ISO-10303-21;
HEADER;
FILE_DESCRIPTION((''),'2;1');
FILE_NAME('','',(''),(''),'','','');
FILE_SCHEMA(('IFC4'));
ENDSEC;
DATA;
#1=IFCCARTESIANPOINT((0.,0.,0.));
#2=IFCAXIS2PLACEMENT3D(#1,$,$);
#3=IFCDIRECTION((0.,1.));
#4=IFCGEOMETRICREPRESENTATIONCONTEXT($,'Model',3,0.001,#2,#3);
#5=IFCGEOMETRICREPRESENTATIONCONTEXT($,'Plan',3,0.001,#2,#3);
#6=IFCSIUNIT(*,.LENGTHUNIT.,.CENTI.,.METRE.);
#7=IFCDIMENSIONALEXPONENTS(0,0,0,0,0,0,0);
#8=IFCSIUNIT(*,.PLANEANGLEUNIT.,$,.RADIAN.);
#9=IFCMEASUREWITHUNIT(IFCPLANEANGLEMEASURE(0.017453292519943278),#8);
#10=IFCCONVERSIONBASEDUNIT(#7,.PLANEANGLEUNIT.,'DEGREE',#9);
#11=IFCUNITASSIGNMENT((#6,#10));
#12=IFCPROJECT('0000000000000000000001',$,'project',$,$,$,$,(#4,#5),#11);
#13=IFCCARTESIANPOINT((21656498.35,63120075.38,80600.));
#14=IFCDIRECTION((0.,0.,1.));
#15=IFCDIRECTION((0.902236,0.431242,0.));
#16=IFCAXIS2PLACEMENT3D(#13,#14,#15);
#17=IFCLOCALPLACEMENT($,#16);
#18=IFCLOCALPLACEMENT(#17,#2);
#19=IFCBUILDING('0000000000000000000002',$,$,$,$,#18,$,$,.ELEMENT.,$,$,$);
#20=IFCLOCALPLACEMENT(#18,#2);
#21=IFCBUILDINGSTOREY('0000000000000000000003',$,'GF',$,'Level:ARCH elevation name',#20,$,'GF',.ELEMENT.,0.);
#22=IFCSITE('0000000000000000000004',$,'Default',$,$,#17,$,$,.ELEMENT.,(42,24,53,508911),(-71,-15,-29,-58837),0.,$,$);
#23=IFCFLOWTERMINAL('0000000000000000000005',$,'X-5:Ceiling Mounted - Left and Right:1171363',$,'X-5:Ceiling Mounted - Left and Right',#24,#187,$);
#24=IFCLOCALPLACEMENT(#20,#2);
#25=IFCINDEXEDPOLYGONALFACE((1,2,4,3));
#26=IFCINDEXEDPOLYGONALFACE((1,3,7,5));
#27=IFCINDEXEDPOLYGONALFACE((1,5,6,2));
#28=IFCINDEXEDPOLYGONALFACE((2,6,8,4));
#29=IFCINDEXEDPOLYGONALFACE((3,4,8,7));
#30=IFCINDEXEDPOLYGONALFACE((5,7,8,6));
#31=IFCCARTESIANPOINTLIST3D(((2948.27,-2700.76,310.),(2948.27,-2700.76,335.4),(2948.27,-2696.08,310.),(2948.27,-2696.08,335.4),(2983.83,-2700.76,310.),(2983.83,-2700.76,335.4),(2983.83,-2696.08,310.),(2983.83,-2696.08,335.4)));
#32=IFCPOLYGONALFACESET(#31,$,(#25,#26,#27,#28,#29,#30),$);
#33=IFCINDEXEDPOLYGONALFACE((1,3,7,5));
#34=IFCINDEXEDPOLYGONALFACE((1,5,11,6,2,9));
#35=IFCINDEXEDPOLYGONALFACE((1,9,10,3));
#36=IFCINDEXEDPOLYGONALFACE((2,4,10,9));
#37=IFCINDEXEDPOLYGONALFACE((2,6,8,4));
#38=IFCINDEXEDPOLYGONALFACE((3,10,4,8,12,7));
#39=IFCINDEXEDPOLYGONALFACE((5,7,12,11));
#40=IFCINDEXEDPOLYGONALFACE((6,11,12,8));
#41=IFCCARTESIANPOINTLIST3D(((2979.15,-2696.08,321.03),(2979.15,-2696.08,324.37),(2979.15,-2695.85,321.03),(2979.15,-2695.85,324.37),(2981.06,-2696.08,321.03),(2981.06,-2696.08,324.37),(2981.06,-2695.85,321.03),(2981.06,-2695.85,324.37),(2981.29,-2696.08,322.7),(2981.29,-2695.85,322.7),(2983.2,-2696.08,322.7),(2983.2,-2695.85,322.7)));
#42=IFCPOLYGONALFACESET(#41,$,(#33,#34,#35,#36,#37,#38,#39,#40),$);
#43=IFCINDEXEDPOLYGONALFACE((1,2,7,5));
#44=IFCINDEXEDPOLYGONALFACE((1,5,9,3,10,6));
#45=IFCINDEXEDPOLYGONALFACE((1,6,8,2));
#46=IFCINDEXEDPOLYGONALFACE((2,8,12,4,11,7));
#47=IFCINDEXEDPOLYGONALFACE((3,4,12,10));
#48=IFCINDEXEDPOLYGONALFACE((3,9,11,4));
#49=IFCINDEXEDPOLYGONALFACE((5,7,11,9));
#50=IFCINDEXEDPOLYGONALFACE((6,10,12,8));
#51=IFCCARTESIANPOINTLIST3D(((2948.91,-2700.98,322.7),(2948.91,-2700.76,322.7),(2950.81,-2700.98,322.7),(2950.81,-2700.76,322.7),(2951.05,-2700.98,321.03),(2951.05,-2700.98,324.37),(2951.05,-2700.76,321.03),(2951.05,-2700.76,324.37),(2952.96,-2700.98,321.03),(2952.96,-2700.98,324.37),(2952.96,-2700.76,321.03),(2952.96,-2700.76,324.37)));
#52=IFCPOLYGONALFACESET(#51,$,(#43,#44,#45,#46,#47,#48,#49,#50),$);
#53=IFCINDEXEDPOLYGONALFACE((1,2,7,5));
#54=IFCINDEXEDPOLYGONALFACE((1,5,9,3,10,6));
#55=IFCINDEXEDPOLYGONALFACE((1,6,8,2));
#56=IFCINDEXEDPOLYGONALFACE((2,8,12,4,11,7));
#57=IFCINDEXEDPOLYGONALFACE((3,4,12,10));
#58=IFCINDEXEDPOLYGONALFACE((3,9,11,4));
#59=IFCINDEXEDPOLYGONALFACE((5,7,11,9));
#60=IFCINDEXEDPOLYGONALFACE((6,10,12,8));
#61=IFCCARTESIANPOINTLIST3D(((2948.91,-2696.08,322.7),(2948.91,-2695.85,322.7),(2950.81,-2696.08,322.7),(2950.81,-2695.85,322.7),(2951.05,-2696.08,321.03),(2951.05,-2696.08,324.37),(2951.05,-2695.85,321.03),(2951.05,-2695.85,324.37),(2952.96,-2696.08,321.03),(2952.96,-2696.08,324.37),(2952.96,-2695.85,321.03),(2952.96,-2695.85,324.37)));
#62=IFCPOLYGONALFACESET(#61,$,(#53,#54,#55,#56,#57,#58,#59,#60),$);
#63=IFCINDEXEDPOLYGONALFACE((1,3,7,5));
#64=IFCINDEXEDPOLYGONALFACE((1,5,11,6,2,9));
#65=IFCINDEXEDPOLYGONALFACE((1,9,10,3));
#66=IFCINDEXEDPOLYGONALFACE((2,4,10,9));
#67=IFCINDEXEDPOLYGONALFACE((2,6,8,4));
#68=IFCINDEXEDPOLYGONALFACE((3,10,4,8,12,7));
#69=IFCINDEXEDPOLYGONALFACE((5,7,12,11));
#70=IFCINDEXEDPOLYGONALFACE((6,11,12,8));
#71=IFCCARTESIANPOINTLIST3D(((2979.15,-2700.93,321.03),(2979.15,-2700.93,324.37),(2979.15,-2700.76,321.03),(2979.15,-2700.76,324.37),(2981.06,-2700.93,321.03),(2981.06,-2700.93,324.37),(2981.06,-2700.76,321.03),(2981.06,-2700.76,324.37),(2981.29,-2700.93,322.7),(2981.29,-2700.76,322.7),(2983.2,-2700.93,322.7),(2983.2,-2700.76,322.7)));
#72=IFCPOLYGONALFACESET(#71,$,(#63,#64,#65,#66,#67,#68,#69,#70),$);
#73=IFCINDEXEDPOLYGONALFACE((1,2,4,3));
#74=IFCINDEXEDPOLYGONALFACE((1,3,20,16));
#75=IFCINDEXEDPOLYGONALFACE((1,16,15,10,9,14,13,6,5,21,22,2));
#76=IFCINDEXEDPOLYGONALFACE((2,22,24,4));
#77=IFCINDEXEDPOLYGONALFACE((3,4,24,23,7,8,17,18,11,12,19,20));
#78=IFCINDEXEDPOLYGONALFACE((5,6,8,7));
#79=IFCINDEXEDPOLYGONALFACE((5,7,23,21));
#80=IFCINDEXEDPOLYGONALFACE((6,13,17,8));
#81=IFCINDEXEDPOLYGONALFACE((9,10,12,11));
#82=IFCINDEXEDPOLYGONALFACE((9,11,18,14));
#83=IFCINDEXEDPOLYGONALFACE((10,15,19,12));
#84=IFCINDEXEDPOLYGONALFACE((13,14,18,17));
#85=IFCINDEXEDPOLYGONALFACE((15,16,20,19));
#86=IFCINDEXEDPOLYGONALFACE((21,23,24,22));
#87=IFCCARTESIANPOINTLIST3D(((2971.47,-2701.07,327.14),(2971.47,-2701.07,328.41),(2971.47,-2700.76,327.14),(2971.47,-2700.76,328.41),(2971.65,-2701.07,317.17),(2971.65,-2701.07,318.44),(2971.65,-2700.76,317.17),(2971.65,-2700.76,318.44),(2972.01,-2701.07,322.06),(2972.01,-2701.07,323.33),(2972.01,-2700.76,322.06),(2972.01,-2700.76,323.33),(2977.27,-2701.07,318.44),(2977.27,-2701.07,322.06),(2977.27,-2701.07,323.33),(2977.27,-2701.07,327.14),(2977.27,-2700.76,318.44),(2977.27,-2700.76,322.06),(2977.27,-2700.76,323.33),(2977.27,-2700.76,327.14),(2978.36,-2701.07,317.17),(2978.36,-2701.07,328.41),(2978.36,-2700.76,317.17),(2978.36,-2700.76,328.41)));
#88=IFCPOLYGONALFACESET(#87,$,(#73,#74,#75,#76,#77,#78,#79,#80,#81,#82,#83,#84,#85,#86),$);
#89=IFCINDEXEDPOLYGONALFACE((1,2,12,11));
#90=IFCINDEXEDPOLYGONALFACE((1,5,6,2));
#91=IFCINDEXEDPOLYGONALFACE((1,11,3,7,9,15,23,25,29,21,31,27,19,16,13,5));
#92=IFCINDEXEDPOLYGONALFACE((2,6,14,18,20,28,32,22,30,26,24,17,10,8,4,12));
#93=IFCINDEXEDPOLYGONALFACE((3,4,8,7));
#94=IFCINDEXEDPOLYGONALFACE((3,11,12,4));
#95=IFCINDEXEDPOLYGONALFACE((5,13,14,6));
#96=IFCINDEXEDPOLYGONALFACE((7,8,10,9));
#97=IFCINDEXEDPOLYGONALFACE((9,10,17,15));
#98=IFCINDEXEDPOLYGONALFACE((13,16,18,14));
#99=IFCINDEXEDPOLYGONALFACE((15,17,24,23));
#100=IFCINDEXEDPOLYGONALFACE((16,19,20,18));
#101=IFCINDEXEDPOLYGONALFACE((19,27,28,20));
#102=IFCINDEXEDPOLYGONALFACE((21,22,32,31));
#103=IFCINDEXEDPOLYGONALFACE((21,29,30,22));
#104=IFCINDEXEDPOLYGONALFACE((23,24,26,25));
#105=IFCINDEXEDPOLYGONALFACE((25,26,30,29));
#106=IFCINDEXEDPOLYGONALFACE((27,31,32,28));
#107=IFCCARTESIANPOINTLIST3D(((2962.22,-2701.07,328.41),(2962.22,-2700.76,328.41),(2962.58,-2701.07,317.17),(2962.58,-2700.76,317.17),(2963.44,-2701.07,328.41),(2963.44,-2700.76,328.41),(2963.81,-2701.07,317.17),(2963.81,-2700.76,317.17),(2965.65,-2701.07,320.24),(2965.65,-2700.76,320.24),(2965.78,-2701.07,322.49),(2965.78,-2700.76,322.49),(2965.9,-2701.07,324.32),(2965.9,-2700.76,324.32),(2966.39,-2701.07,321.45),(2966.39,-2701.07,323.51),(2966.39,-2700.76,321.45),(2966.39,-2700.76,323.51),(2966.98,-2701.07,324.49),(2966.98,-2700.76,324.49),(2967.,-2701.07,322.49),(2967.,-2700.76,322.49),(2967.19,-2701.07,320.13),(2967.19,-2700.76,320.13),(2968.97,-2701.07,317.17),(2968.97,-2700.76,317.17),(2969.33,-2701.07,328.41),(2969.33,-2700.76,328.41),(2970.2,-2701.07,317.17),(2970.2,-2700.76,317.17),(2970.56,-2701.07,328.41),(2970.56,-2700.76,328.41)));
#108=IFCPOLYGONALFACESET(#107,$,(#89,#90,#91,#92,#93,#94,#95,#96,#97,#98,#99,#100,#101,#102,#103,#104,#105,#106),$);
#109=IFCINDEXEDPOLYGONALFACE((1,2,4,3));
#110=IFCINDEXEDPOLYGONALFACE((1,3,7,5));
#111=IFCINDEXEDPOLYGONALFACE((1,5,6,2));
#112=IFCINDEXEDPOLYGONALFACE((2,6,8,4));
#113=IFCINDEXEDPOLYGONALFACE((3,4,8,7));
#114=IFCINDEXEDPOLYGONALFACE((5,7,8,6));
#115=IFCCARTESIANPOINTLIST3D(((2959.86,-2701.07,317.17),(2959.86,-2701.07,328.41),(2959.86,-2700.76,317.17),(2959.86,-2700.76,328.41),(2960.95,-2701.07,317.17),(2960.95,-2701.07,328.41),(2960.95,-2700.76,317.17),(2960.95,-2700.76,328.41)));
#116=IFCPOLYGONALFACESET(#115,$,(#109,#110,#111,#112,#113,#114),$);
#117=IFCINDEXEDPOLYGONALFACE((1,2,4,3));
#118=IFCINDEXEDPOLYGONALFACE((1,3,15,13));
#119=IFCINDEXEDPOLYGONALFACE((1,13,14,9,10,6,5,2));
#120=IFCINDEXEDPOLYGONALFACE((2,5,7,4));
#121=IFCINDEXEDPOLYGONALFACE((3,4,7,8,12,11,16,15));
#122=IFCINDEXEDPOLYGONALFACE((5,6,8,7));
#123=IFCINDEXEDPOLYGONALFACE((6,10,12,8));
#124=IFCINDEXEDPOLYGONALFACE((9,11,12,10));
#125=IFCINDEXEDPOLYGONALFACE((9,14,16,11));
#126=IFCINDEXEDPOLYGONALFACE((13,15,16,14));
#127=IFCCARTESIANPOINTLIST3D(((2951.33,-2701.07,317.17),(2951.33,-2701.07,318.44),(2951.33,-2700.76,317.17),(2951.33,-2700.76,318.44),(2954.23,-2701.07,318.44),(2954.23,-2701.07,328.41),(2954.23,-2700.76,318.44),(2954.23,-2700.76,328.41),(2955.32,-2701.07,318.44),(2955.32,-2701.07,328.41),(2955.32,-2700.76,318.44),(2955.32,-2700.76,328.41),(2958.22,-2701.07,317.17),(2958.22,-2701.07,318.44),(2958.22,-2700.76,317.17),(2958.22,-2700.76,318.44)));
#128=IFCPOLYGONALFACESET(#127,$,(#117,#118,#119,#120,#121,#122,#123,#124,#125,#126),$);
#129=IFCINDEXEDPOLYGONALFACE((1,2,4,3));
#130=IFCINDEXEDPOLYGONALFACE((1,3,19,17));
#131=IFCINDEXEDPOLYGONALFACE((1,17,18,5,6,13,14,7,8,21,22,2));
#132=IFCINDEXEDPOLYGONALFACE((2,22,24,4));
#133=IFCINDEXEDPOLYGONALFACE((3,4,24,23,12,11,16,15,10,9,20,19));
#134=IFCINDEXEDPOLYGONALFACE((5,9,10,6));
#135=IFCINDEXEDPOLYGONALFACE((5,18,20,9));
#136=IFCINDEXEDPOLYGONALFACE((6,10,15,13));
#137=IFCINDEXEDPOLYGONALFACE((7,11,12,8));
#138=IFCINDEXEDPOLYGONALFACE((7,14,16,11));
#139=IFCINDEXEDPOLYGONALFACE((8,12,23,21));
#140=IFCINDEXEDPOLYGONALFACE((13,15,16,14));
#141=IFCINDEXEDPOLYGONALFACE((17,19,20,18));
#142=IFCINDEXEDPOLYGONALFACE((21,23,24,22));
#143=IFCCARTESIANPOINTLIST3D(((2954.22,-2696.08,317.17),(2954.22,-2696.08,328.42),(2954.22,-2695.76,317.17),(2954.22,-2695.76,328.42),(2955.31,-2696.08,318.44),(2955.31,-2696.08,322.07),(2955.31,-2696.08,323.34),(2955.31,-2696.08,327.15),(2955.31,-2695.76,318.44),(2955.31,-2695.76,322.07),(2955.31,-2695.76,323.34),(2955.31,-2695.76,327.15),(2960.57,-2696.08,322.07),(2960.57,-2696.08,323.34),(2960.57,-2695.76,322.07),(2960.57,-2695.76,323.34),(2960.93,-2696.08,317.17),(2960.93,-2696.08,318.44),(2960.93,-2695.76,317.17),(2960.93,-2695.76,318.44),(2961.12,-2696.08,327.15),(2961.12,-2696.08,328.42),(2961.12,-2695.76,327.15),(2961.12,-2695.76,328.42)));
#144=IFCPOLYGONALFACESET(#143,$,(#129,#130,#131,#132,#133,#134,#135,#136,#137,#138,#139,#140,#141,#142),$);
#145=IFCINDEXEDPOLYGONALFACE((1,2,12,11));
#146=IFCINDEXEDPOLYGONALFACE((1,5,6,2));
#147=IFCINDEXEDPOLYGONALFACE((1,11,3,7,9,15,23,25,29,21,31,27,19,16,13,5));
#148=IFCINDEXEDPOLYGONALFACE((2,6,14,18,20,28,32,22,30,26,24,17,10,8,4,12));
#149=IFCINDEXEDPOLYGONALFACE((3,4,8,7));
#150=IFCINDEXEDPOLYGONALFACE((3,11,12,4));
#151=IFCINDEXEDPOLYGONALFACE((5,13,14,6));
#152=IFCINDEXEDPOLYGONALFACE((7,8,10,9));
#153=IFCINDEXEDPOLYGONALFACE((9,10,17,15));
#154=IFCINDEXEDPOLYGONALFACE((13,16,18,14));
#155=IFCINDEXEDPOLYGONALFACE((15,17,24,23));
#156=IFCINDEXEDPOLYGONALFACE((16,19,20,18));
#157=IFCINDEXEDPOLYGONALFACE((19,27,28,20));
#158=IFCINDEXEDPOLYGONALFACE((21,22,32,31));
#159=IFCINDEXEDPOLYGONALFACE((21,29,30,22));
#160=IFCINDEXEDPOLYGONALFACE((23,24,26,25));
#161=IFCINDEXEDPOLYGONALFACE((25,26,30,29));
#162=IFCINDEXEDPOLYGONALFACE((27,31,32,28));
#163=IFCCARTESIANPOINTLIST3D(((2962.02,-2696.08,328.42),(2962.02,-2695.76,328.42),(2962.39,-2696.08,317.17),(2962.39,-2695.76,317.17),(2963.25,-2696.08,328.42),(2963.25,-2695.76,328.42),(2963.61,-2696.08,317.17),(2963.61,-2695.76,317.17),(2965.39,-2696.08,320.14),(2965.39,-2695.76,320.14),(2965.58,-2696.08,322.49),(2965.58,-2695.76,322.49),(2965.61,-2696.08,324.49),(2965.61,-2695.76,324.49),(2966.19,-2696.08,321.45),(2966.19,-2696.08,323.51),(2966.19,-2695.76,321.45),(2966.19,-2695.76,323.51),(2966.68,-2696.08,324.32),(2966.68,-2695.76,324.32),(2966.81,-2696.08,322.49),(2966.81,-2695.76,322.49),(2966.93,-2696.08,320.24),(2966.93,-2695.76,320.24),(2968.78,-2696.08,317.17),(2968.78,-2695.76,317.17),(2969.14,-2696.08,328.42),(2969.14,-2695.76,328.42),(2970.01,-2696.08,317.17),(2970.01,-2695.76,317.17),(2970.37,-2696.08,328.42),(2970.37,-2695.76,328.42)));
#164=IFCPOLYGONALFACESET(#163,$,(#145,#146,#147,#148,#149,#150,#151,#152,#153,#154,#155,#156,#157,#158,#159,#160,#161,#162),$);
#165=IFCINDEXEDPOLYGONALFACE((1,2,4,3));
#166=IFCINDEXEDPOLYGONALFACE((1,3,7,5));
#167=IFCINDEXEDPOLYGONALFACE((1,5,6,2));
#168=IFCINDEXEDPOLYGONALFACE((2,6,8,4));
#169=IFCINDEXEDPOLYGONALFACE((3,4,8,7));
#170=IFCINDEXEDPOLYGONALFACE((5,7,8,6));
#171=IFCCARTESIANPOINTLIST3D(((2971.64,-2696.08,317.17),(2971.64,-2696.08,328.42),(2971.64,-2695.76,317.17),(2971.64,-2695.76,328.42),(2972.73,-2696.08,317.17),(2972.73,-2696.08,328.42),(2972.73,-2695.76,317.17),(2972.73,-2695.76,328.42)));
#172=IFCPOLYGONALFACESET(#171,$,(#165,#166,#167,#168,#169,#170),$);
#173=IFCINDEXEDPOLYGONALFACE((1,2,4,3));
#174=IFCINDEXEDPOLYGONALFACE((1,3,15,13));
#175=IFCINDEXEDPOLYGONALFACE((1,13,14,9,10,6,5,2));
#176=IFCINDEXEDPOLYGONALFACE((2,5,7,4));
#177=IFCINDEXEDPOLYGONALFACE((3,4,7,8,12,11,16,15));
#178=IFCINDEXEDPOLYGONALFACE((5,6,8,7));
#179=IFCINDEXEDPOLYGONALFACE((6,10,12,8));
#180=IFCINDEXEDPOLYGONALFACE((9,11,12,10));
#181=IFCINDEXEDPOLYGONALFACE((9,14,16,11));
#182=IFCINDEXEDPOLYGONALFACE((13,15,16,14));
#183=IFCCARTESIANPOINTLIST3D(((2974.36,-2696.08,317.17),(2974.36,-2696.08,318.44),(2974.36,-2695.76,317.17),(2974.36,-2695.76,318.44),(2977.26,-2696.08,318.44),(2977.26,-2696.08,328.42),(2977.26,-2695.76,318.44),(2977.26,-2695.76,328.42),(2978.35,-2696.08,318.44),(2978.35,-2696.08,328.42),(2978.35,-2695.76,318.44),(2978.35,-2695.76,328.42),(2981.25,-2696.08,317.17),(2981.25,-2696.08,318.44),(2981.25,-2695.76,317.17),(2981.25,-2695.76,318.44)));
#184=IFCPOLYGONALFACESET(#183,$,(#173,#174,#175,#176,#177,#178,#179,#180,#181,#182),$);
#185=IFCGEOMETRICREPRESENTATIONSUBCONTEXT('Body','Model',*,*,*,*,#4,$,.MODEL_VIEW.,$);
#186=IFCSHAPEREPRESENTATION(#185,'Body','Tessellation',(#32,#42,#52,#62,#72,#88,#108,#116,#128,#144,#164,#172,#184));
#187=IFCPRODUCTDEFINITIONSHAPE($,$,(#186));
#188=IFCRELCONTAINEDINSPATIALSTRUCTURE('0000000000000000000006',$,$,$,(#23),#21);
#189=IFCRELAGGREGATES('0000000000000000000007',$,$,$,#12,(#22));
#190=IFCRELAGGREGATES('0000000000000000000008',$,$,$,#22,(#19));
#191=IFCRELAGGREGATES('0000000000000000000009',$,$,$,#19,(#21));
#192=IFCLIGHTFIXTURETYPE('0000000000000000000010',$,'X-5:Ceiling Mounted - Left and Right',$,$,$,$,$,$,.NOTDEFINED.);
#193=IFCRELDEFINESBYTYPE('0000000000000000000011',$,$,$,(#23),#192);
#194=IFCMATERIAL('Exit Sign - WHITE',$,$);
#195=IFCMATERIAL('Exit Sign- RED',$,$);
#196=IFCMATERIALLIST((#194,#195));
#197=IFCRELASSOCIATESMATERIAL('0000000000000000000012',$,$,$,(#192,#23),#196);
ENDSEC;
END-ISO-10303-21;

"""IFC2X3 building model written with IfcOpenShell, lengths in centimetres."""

from ifc_helpers import new_model, entity, si_unit, converted_unit, direction, frame, frame_2d, origin, place, context, subcontext, project, spatial, polyline, rectangle, outline, extrude, source, transform, mapped, material, material_list, type_object, type_shapes, element, save


model = new_model("IFC2X3")

# Units and contexts
model_context = context("Model", 3, precision=0.001, world=origin(), true_north=direction((0.0, 1.0)))
plan_context = context("Plan", 3, precision=0.001, world=origin(), true_north=direction((0.0, 1.0)))
body_context = subcontext(model_context, "Body", "Model", "MODEL_VIEW")
ifc_project = project(units=[si_unit("LENGTHUNIT", "METRE", prefix="CENTI"), converted_unit("PLANEANGLEUNIT", "DEGREE", entity("IfcPlaneAngleMeasure", 0.017453292519943278), si_unit("PLANEANGLEUNIT", "RADIAN"), dimensions=[0, 0, 0, 0, 0, 0, 0])], contexts=[model_context, plan_context])

# Site, building, storey
site_placement = place(None, frame((21656498.35, 63120075.38, 80600.0), z_axis=(0.0, 0.0, 1.0), x_axis=(0.902236, 0.431242, 0.0)))
site = spatial("IfcSite", under=ifc_project, at=site_placement, Name="Default", CompositionType="ELEMENT", RefLatitude=(42, 24, 53, 508911), RefLongitude=(-71, -15, -29, -58837), RefElevation=0.0)
building_placement = place(site_placement, origin())
building = spatial("IfcBuilding", under=site, at=building_placement, CompositionType="ELEMENT")
storey_placement = place(building_placement, origin())
storey = spatial("IfcBuildingStorey", under=building, at=storey_placement, Name="GF", ObjectType="Level:ARCH elevation name", LongName="GF", CompositionType="ELEMENT", Elevation=0.0)

# Flow terminal
ifc_material_1 = material(Name="Exit Sign - WHITE")
ifc_material_2 = material(Name="Exit Sign- RED")
ifc_material_list_1 = material_list([ifc_material_1, ifc_material_2])
light_fixture_type = type_object("IfcLightFixtureType", Name="X-5:Ceiling Mounted - Left and Right", PredefinedType="NOTDEFINED", material=ifc_material_list_1)
shared_shape_1 = source(origin(), body_context, "Body", "SweptSolid", [
    extrude(rectangle(XDim=4.68, YDim=35.56, at=frame_2d((0.0, 0.0), x_axis=(1.0, 0.0))), frame((0.0, 1.02, -25.4), z_axis=(0.0, 0.0, 1.0), x_axis=(0.0, 1.0, 0.0)), (0.0, 0.0, 1.0), 25.4),
    extrude(outline(polyline([(-0.24, -1.67), (1.67, -1.67), (-0.47, 0.0), (1.67, 1.67), (-0.24, 1.67), (-2.38, 0.0), (-0.24, -1.67)])), frame((-14.77, 3.36, -12.7), z_axis=(0.0, 1.0, 0.0), x_axis=(1.0, 0.0, 0.0)), (0.0, 0.0, 1.0), 0.22),
    extrude(outline(polyline([(-0.84, -1.47), (1.88, -1.47), (1.22, 1.17), (-0.28, 2.34), (0.37, -0.29), (-2.34, -0.29), (-0.84, -1.47)])), frame((14.77, -1.54, -12.7), z_axis=(0.0, 1.0, 0.0), x_axis=(0.788011, 0.0, -0.615661)), (0.0, 0.0, 1.0), 0.22),
    extrude(outline(polyline([(-0.84, -1.47), (1.88, -1.47), (1.22, 1.17), (-0.28, 2.34), (0.37, -0.29), (-2.34, -0.29), (-0.84, -1.47)])), frame((14.77, 3.36, -12.7), z_axis=(0.0, 1.0, 0.0), x_axis=(0.788011, 0.0, -0.615661)), (0.0, 0.0, 1.0), 0.22),
    extrude(outline(polyline([(-0.24, -1.67), (1.67, -1.67), (-0.47, 0.0), (1.67, 1.67), (-0.24, 1.67), (-2.38, 0.0), (-0.24, -1.67)])), frame((-14.77, -1.49, -12.7), z_axis=(0.0, 1.0, 0.0), x_axis=(1.0, 0.0, 0.0)), (0.0, 0.0, 1.0), 0.18),
    extrude(outline(polyline([(-5.65, -3.69), (5.59, -3.69), (5.59, 3.02), (4.32, 3.02), (4.32, -2.6), (0.7, -2.6), (0.7, 2.66), (-0.57, 2.66), (-0.57, -2.6), (-4.38, -2.6), (-4.38, 3.21), (-5.65, 3.21), (-5.65, -3.69)])), frame((-8.62, -1.63, -12.76), z_axis=(0.0, 1.0, 0.0), x_axis=(0.0, 0.0, 1.0)), (0.0, 0.0, 1.0), 0.32),
    extrude(outline(polyline([(-7.14, 0.57), (-6.5, -0.49), (-1.93, -0.48), (-0.78, -0.48), (-1.23, -1.32), (-3.47, -5.53), (-2.84, -6.59), (0.41, -0.48), (6.62, -0.48), (5.99, 0.57), (2.4, 0.57), (0.98, 0.58), (1.7, 1.94), (3.32, 5.0), (2.69, 6.05), (-0.22, 0.57), (-7.14, 0.57)])), frame((-0.34, -1.63, -12.59), z_axis=(0.0, -1.0, 0.0), x_axis=(0.515099, 0.0, 0.857131)), (0.0, 0.0, -1.0), 0.32),
    extrude(rectangle(XDim=0.32, YDim=1.09, at=frame_2d((0.0, 0.0), x_axis=(1.0, 0.0))), frame((5.65, -1.48, -18.41), z_axis=(0.0, 0.0, 1.0), x_axis=(0.0, 1.0, 0.0)), (0.0, 0.0, 1.0), 11.25),
    extrude(outline(polyline([(-7.8, 0.54), (-7.8, -0.54), (2.18, -0.54), (2.18, -3.45), (3.45, -3.45), (3.45, 3.45), (2.18, 3.45), (2.18, 0.54), (-7.8, 0.54)])), frame((11.28, -1.63, -10.61), z_axis=(0.0, -1.0, 0.0), x_axis=(0.0, 0.0, 1.0)), (0.0, 0.0, -1.0), 0.32),
    extrude(outline(polyline([(-3.69, -5.65), (3.21, -5.65), (3.21, -4.38), (-2.6, -4.38), (-2.6, -0.57), (2.66, -0.57), (2.66, 0.7), (-2.6, 0.7), (-2.6, 4.32), (3.02, 4.32), (3.02, 5.59), (-3.69, 5.59), (-3.69, -5.65)])), frame((8.14, 3.36, -12.76), z_axis=(0.0, 1.0, 0.0), x_axis=(-1.0, 0.0, 0.0)), (0.0, 0.0, 1.0), 0.32),
    extrude(outline(polyline([(-4.16, -5.82), (-2.93, -5.82), (-0.58, -1.9), (0.01, -0.92), (0.5, -1.73), (2.96, -5.82), (4.18, -5.82), (0.62, 0.1), (3.82, 5.42), (2.59, 5.42), (0.75, 2.35), (0.01, 1.14), (-0.79, 2.46), (-2.57, 5.42), (-3.8, 5.42), (-0.6, 0.1), (-4.16, -5.82)])), frame((-0.13, 3.36, -12.59), z_axis=(0.0, 1.0, 0.0), x_axis=(-1.0, 0.0, 0.0)), (0.0, 0.0, 1.0), 0.32),
    extrude(rectangle(XDim=0.32, YDim=1.09, at=frame_2d((0.0, 0.0), x_axis=(1.0, 0.0))), frame((-6.13, 3.52, -18.42), z_axis=(0.0, 0.0, 1.0), x_axis=(0.0, -1.0, 0.0)), (0.0, 0.0, 1.0), 11.25),
    extrude(outline(polyline([(-0.54, -7.8), (0.54, -7.8), (0.54, 2.18), (3.45, 2.18), (3.45, 3.45), (-3.45, 3.45), (-3.45, 2.18), (-0.54, 2.18), (-0.54, -7.8)])), frame((-11.75, 3.36, -10.62), z_axis=(0.0, 1.0, 0.0), x_axis=(-1.0, 0.0, 0.0)), (0.0, 0.0, 1.0), 0.32),
])
type_shapes(light_fixture_type, [shared_shape_1])
flow_terminal_placement = place(storey_placement, frame((2966.05, -2699.44, 310.0), z_axis=(0.0, 0.0, -1.0), x_axis=(-1.0, 0.0, 0.0)))
element("IfcFlowTerminal", 1, at=flow_terminal_placement, inside=storey, type_object=light_fixture_type, material=ifc_material_list_1, Name="X-5:Ceiling Mounted - Left and Right:1171363", ObjectType="X-5:Ceiling Mounted - Left and Right", context=body_context, shape_type="MappedRepresentation", body=[
    mapped(shared_shape_1, transform((0.0, 0.0, 0.0), scale=1.0)),
])

save(model, "model.ifc")
